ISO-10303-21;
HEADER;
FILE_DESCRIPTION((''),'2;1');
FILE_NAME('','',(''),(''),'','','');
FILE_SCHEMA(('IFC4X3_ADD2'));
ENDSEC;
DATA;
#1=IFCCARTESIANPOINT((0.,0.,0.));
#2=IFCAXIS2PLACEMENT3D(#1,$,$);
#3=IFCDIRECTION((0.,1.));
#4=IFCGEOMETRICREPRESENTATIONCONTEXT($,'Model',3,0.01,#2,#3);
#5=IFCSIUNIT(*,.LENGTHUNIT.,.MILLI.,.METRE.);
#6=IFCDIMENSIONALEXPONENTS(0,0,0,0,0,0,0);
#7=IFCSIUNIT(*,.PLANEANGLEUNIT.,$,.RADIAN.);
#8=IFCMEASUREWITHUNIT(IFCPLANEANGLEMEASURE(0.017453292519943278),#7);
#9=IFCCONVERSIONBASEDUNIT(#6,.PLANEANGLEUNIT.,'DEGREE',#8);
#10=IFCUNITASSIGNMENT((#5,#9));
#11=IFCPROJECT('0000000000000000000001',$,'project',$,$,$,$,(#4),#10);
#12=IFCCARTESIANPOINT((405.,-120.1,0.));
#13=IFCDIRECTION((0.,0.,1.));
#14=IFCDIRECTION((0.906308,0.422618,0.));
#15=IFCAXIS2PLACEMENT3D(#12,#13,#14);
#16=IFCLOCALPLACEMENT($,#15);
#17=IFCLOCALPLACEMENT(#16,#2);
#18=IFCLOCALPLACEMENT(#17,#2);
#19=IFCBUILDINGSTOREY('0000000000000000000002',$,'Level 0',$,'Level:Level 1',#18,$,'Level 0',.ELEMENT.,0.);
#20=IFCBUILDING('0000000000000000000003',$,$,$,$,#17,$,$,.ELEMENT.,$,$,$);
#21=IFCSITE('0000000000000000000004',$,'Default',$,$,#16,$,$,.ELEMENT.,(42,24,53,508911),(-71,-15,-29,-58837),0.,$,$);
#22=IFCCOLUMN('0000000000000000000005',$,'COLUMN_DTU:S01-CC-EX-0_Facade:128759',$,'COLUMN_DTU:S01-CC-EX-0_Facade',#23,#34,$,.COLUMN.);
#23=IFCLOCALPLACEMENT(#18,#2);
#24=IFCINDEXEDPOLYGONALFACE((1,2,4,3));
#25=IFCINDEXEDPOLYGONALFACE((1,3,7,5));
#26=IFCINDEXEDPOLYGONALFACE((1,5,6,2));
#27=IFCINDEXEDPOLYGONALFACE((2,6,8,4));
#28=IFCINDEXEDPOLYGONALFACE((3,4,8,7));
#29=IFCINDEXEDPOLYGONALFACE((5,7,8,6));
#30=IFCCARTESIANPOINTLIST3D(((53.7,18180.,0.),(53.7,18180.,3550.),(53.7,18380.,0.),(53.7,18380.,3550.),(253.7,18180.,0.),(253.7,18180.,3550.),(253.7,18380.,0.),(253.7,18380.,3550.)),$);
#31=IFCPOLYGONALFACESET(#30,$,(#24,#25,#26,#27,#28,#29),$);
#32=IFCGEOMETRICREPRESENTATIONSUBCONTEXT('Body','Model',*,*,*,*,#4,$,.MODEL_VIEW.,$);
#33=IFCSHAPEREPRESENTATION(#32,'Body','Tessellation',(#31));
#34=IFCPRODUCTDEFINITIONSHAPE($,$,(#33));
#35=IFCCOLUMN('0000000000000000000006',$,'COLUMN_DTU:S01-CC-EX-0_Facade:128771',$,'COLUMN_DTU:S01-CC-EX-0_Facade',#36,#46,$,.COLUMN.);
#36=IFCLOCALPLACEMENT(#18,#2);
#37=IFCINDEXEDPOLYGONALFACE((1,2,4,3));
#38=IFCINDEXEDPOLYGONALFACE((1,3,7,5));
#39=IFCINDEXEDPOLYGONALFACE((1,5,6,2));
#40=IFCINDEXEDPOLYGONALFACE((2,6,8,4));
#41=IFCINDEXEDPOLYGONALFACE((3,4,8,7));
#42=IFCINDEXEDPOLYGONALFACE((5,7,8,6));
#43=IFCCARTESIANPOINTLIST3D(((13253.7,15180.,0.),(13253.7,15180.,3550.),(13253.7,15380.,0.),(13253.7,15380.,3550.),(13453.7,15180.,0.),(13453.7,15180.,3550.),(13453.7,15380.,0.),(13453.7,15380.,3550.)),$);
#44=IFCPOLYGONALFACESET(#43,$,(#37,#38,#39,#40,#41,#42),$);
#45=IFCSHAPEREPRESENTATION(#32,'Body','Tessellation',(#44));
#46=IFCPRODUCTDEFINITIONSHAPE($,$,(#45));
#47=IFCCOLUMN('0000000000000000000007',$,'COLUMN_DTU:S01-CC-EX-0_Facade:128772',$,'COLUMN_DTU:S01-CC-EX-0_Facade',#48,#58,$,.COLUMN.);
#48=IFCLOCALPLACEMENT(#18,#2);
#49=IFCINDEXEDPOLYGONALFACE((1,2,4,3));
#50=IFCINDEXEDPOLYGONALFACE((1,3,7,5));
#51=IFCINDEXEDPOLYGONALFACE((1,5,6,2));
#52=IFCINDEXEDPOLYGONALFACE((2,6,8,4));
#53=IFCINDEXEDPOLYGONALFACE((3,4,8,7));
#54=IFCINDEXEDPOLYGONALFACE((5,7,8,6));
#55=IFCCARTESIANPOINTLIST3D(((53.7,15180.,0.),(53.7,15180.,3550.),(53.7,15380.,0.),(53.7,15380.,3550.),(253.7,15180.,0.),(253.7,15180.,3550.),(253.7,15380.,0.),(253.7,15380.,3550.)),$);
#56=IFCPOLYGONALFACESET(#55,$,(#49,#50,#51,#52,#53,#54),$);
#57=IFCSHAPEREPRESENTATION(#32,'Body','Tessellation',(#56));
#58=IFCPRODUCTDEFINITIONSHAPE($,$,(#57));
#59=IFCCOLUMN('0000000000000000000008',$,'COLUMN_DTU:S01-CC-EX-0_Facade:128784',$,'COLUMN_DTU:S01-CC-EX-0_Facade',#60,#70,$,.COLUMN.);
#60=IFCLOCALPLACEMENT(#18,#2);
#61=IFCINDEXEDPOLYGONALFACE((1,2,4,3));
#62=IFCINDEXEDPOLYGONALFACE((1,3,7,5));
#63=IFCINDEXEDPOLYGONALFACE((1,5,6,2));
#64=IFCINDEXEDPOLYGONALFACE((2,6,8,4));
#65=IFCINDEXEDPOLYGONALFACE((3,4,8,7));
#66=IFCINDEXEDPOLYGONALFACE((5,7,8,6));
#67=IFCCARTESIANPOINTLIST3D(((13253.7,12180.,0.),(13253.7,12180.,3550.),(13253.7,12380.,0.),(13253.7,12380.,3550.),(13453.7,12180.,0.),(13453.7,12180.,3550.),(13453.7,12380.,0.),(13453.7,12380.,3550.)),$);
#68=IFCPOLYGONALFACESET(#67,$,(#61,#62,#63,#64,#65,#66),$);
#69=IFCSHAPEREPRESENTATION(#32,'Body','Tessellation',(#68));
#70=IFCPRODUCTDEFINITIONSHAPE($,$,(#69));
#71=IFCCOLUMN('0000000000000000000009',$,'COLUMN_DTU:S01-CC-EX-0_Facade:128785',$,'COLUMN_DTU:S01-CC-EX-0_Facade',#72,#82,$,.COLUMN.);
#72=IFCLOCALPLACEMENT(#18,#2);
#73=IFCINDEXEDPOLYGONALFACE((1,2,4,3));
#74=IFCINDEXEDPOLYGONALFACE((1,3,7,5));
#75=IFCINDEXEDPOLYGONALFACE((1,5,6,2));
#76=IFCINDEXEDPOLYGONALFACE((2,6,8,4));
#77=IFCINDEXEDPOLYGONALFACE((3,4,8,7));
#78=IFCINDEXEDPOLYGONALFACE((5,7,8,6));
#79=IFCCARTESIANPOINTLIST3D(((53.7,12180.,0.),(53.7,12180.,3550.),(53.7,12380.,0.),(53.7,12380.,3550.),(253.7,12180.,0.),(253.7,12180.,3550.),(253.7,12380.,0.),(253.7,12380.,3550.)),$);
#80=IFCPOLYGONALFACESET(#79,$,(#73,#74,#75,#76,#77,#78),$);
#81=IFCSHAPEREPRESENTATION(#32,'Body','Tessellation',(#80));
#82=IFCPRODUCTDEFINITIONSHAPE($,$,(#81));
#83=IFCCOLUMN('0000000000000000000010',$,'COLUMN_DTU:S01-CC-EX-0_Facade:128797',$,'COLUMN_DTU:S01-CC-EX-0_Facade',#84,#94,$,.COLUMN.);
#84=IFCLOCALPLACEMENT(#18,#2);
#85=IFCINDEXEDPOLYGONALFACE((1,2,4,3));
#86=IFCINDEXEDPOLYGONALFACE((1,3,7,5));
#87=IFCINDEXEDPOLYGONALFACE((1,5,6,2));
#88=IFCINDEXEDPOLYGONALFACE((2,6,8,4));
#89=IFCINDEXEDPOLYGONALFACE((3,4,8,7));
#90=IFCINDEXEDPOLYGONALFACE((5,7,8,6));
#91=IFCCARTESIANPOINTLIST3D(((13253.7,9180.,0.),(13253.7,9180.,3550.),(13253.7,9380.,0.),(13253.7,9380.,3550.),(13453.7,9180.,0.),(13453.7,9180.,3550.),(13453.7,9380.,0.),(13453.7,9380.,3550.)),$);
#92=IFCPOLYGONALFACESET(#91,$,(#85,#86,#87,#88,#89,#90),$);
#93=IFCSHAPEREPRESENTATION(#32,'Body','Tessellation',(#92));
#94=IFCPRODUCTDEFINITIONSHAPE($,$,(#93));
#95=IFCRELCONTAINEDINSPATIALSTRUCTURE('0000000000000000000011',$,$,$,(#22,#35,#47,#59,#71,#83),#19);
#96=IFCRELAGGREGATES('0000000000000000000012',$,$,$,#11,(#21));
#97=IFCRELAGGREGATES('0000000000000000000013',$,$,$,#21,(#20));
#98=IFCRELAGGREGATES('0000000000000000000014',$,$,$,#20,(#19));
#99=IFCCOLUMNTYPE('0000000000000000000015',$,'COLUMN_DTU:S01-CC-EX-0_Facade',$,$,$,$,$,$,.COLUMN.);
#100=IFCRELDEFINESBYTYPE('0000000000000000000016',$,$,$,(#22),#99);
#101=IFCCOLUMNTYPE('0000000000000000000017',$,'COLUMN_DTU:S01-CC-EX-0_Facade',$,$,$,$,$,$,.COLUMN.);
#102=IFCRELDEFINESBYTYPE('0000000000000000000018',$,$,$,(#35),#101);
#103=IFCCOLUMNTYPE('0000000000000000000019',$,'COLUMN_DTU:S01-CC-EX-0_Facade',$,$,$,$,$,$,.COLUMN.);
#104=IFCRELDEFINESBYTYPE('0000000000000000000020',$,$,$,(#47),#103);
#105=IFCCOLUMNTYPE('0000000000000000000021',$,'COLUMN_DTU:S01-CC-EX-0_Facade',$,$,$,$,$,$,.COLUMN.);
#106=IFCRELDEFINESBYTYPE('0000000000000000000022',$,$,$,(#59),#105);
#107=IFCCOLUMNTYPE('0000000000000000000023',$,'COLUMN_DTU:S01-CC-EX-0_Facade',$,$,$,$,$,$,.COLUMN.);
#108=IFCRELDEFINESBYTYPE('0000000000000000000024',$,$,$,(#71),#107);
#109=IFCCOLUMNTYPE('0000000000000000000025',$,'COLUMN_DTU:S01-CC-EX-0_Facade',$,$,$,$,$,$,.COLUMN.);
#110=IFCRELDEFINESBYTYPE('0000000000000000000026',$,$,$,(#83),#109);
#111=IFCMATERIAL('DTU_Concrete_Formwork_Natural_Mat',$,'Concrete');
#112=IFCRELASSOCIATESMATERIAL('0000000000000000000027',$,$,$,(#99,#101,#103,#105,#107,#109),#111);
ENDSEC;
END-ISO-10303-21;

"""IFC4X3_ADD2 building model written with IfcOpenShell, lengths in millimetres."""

from ifc_helpers import new_model, entity, si_unit, converted_unit, direction, frame, frame_2d, origin, place, context, subcontext, project, spatial, rectangle, extrude, source, transform, mapped, material, material_profile, profile_set, type_object, type_shapes, element, save


model = new_model("IFC4X3_ADD2")

# Units and contexts
model_context = context("Model", 3, precision=0.01, world=origin(), true_north=direction((0.0, 1.0)))
body_context = subcontext(model_context, "Body", "Model", "MODEL_VIEW")
ifc_project = project(units=[si_unit("LENGTHUNIT", "METRE", prefix="MILLI"), converted_unit("PLANEANGLEUNIT", "DEGREE", entity("IfcPlaneAngleMeasure", 0.017453292519943278), si_unit("PLANEANGLEUNIT", "RADIAN"), dimensions=[0, 0, 0, 0, 0, 0, 0])], contexts=[model_context])

# Site, building, storey
site_placement = place(None, frame((405.0, -120.1, 0.0), z_axis=(0.0, 0.0, 1.0), x_axis=(0.906308, 0.422618, 0.0)))
site = spatial("IfcSite", under=ifc_project, at=site_placement, Name="Default", CompositionType="ELEMENT", RefLatitude=(42, 24, 53, 508911), RefLongitude=(-71, -15, -29, -58837), RefElevation=0.0)
building_placement = place(site_placement, origin())
building = spatial("IfcBuilding", under=site, at=building_placement, CompositionType="ELEMENT")
storey_placement = place(building_placement, origin())
storey = spatial("IfcBuildingStorey", under=building, at=storey_placement, Name="Level 0", ObjectType="Level:Level 1", LongName="Level 0", CompositionType="ELEMENT", Elevation=0.0)

# Columns
ifc_material = material(Name="DTU_Concrete_Formwork_Natural_Mat", Category="Concrete")
ifc_material_profile_1 = material_profile(ifc_material, rectangle(XDim=200.0, YDim=200.0, at=frame_2d((0.0, 0.0), x_axis=(1.0, 0.0))), Name="S01-CC-EX-0_Facade")
ifc_profile_set_1 = profile_set([ifc_material_profile_1], Name="S01-CC-EX-0_Facade")
column_type_1 = type_object("IfcColumnType", Name="COLUMN_DTU:S01-CC-EX-0_Facade", PredefinedType="COLUMN", material=ifc_profile_set_1)
shared_shape_1 = source(origin(), body_context, "Body", "SweptSolid", [
    extrude(rectangle(XDim=200.0, YDim=200.0, at=frame_2d((0.0, 0.0), x_axis=(1.0, 0.0))), frame((153.7, 18280.0, 0.0), z_axis=(0.0, 0.0, 1.0), x_axis=(0.0, 1.0, 0.0)), (0.0, 0.0, 1.0), 3550.0),
])
type_shapes(column_type_1, [shared_shape_1])
column_1_placement = place(storey_placement, origin())
element("IfcColumn", 1, at=column_1_placement, inside=storey, type_object=column_type_1, Name="COLUMN_DTU:S01-CC-EX-0_Facade:128759", ObjectType="COLUMN_DTU:S01-CC-EX-0_Facade", PredefinedType="COLUMN", context=body_context, shape_type="MappedRepresentation", body=[
    mapped(shared_shape_1, transform((0.0, 0.0, 0.0), scale=1.0)),
])
column_type_2 = type_object("IfcColumnType", Name="COLUMN_DTU:S01-CC-EX-0_Facade", PredefinedType="COLUMN", material=ifc_profile_set_1)
shared_shape_2 = source(origin(), body_context, "Body", "SweptSolid", [
    extrude(rectangle(XDim=200.0, YDim=200.0, at=frame_2d((0.0, 0.0), x_axis=(1.0, 0.0))), frame((13353.7, 15280.0, 0.0), z_axis=(0.0, 0.0, 1.0), x_axis=(0.0, 1.0, 0.0)), (0.0, 0.0, 1.0), 3550.0),
])
type_shapes(column_type_2, [shared_shape_2])
column_2_placement = place(storey_placement, origin())
element("IfcColumn", 2, at=column_2_placement, inside=storey, type_object=column_type_2, Name="COLUMN_DTU:S01-CC-EX-0_Facade:128771", ObjectType="COLUMN_DTU:S01-CC-EX-0_Facade", PredefinedType="COLUMN", context=body_context, shape_type="MappedRepresentation", body=[
    mapped(shared_shape_2, transform((0.0, 0.0, 0.0), scale=1.0)),
])
column_type_3 = type_object("IfcColumnType", Name="COLUMN_DTU:S01-CC-EX-0_Facade", PredefinedType="COLUMN", material=ifc_profile_set_1)
shared_shape_3 = source(origin(), body_context, "Body", "SweptSolid", [
    extrude(rectangle(XDim=200.0, YDim=200.0, at=frame_2d((0.0, 0.0), x_axis=(1.0, 0.0))), frame((153.7, 15280.0, 0.0), z_axis=(0.0, 0.0, 1.0), x_axis=(0.0, 1.0, 0.0)), (0.0, 0.0, 1.0), 3550.0),
])
type_shapes(column_type_3, [shared_shape_3])
column_3_placement = place(storey_placement, origin())
element("IfcColumn", 3, at=column_3_placement, inside=storey, type_object=column_type_3, Name="COLUMN_DTU:S01-CC-EX-0_Facade:128772", ObjectType="COLUMN_DTU:S01-CC-EX-0_Facade", PredefinedType="COLUMN", context=body_context, shape_type="MappedRepresentation", body=[
    mapped(shared_shape_3, transform((0.0, 0.0, 0.0), scale=1.0)),
])
column_type_4 = type_object("IfcColumnType", Name="COLUMN_DTU:S01-CC-EX-0_Facade", PredefinedType="COLUMN", material=ifc_profile_set_1)
shared_shape_4 = source(origin(), body_context, "Body", "SweptSolid", [
    extrude(rectangle(XDim=200.0, YDim=200.0, at=frame_2d((0.0, 0.0), x_axis=(1.0, 0.0))), frame((13353.7, 12280.0, 0.0), z_axis=(0.0, 0.0, 1.0), x_axis=(0.0, 1.0, 0.0)), (0.0, 0.0, 1.0), 3550.0),
])
type_shapes(column_type_4, [shared_shape_4])
column_4_placement = place(storey_placement, origin())
element("IfcColumn", 4, at=column_4_placement, inside=storey, type_object=column_type_4, Name="COLUMN_DTU:S01-CC-EX-0_Facade:128784", ObjectType="COLUMN_DTU:S01-CC-EX-0_Facade", PredefinedType="COLUMN", context=body_context, shape_type="MappedRepresentation", body=[
    mapped(shared_shape_4, transform((0.0, 0.0, 0.0), scale=1.0)),
])
column_type_5 = type_object("IfcColumnType", Name="COLUMN_DTU:S01-CC-EX-0_Facade", PredefinedType="COLUMN", material=ifc_profile_set_1)
shared_shape_5 = source(origin(), body_context, "Body", "SweptSolid", [
    extrude(rectangle(XDim=200.0, YDim=200.0, at=frame_2d((0.0, 0.0), x_axis=(1.0, 0.0))), frame((153.7, 12280.0, 0.0), z_axis=(0.0, 0.0, 1.0), x_axis=(0.0, 1.0, 0.0)), (0.0, 0.0, 1.0), 3550.0),
])
type_shapes(column_type_5, [shared_shape_5])
column_5_placement = place(storey_placement, origin())
element("IfcColumn", 5, at=column_5_placement, inside=storey, type_object=column_type_5, Name="COLUMN_DTU:S01-CC-EX-0_Facade:128785", ObjectType="COLUMN_DTU:S01-CC-EX-0_Facade", PredefinedType="COLUMN", context=body_context, shape_type="MappedRepresentation", body=[
    mapped(shared_shape_5, transform((0.0, 0.0, 0.0), scale=1.0)),
])
column_type_6 = type_object("IfcColumnType", Name="COLUMN_DTU:S01-CC-EX-0_Facade", PredefinedType="COLUMN", material=ifc_profile_set_1)
shared_shape_6 = source(origin(), body_context, "Body", "SweptSolid", [
    extrude(rectangle(XDim=200.0, YDim=200.0, at=frame_2d((0.0, 0.0), x_axis=(1.0, 0.0))), frame((13353.7, 9280.0, 0.0), z_axis=(0.0, 0.0, 1.0), x_axis=(0.0, 1.0, 0.0)), (0.0, 0.0, 1.0), 3550.0),
])
type_shapes(column_type_6, [shared_shape_6])
column_6_placement = place(storey_placement, origin())
element("IfcColumn", 6, at=column_6_placement, inside=storey, type_object=column_type_6, Name="COLUMN_DTU:S01-CC-EX-0_Facade:128797", ObjectType="COLUMN_DTU:S01-CC-EX-0_Facade", PredefinedType="COLUMN", context=body_context, shape_type="MappedRepresentation", body=[
    mapped(shared_shape_6, transform((0.0, 0.0, 0.0), scale=1.0)),
])

save(model, "model.ifc")
